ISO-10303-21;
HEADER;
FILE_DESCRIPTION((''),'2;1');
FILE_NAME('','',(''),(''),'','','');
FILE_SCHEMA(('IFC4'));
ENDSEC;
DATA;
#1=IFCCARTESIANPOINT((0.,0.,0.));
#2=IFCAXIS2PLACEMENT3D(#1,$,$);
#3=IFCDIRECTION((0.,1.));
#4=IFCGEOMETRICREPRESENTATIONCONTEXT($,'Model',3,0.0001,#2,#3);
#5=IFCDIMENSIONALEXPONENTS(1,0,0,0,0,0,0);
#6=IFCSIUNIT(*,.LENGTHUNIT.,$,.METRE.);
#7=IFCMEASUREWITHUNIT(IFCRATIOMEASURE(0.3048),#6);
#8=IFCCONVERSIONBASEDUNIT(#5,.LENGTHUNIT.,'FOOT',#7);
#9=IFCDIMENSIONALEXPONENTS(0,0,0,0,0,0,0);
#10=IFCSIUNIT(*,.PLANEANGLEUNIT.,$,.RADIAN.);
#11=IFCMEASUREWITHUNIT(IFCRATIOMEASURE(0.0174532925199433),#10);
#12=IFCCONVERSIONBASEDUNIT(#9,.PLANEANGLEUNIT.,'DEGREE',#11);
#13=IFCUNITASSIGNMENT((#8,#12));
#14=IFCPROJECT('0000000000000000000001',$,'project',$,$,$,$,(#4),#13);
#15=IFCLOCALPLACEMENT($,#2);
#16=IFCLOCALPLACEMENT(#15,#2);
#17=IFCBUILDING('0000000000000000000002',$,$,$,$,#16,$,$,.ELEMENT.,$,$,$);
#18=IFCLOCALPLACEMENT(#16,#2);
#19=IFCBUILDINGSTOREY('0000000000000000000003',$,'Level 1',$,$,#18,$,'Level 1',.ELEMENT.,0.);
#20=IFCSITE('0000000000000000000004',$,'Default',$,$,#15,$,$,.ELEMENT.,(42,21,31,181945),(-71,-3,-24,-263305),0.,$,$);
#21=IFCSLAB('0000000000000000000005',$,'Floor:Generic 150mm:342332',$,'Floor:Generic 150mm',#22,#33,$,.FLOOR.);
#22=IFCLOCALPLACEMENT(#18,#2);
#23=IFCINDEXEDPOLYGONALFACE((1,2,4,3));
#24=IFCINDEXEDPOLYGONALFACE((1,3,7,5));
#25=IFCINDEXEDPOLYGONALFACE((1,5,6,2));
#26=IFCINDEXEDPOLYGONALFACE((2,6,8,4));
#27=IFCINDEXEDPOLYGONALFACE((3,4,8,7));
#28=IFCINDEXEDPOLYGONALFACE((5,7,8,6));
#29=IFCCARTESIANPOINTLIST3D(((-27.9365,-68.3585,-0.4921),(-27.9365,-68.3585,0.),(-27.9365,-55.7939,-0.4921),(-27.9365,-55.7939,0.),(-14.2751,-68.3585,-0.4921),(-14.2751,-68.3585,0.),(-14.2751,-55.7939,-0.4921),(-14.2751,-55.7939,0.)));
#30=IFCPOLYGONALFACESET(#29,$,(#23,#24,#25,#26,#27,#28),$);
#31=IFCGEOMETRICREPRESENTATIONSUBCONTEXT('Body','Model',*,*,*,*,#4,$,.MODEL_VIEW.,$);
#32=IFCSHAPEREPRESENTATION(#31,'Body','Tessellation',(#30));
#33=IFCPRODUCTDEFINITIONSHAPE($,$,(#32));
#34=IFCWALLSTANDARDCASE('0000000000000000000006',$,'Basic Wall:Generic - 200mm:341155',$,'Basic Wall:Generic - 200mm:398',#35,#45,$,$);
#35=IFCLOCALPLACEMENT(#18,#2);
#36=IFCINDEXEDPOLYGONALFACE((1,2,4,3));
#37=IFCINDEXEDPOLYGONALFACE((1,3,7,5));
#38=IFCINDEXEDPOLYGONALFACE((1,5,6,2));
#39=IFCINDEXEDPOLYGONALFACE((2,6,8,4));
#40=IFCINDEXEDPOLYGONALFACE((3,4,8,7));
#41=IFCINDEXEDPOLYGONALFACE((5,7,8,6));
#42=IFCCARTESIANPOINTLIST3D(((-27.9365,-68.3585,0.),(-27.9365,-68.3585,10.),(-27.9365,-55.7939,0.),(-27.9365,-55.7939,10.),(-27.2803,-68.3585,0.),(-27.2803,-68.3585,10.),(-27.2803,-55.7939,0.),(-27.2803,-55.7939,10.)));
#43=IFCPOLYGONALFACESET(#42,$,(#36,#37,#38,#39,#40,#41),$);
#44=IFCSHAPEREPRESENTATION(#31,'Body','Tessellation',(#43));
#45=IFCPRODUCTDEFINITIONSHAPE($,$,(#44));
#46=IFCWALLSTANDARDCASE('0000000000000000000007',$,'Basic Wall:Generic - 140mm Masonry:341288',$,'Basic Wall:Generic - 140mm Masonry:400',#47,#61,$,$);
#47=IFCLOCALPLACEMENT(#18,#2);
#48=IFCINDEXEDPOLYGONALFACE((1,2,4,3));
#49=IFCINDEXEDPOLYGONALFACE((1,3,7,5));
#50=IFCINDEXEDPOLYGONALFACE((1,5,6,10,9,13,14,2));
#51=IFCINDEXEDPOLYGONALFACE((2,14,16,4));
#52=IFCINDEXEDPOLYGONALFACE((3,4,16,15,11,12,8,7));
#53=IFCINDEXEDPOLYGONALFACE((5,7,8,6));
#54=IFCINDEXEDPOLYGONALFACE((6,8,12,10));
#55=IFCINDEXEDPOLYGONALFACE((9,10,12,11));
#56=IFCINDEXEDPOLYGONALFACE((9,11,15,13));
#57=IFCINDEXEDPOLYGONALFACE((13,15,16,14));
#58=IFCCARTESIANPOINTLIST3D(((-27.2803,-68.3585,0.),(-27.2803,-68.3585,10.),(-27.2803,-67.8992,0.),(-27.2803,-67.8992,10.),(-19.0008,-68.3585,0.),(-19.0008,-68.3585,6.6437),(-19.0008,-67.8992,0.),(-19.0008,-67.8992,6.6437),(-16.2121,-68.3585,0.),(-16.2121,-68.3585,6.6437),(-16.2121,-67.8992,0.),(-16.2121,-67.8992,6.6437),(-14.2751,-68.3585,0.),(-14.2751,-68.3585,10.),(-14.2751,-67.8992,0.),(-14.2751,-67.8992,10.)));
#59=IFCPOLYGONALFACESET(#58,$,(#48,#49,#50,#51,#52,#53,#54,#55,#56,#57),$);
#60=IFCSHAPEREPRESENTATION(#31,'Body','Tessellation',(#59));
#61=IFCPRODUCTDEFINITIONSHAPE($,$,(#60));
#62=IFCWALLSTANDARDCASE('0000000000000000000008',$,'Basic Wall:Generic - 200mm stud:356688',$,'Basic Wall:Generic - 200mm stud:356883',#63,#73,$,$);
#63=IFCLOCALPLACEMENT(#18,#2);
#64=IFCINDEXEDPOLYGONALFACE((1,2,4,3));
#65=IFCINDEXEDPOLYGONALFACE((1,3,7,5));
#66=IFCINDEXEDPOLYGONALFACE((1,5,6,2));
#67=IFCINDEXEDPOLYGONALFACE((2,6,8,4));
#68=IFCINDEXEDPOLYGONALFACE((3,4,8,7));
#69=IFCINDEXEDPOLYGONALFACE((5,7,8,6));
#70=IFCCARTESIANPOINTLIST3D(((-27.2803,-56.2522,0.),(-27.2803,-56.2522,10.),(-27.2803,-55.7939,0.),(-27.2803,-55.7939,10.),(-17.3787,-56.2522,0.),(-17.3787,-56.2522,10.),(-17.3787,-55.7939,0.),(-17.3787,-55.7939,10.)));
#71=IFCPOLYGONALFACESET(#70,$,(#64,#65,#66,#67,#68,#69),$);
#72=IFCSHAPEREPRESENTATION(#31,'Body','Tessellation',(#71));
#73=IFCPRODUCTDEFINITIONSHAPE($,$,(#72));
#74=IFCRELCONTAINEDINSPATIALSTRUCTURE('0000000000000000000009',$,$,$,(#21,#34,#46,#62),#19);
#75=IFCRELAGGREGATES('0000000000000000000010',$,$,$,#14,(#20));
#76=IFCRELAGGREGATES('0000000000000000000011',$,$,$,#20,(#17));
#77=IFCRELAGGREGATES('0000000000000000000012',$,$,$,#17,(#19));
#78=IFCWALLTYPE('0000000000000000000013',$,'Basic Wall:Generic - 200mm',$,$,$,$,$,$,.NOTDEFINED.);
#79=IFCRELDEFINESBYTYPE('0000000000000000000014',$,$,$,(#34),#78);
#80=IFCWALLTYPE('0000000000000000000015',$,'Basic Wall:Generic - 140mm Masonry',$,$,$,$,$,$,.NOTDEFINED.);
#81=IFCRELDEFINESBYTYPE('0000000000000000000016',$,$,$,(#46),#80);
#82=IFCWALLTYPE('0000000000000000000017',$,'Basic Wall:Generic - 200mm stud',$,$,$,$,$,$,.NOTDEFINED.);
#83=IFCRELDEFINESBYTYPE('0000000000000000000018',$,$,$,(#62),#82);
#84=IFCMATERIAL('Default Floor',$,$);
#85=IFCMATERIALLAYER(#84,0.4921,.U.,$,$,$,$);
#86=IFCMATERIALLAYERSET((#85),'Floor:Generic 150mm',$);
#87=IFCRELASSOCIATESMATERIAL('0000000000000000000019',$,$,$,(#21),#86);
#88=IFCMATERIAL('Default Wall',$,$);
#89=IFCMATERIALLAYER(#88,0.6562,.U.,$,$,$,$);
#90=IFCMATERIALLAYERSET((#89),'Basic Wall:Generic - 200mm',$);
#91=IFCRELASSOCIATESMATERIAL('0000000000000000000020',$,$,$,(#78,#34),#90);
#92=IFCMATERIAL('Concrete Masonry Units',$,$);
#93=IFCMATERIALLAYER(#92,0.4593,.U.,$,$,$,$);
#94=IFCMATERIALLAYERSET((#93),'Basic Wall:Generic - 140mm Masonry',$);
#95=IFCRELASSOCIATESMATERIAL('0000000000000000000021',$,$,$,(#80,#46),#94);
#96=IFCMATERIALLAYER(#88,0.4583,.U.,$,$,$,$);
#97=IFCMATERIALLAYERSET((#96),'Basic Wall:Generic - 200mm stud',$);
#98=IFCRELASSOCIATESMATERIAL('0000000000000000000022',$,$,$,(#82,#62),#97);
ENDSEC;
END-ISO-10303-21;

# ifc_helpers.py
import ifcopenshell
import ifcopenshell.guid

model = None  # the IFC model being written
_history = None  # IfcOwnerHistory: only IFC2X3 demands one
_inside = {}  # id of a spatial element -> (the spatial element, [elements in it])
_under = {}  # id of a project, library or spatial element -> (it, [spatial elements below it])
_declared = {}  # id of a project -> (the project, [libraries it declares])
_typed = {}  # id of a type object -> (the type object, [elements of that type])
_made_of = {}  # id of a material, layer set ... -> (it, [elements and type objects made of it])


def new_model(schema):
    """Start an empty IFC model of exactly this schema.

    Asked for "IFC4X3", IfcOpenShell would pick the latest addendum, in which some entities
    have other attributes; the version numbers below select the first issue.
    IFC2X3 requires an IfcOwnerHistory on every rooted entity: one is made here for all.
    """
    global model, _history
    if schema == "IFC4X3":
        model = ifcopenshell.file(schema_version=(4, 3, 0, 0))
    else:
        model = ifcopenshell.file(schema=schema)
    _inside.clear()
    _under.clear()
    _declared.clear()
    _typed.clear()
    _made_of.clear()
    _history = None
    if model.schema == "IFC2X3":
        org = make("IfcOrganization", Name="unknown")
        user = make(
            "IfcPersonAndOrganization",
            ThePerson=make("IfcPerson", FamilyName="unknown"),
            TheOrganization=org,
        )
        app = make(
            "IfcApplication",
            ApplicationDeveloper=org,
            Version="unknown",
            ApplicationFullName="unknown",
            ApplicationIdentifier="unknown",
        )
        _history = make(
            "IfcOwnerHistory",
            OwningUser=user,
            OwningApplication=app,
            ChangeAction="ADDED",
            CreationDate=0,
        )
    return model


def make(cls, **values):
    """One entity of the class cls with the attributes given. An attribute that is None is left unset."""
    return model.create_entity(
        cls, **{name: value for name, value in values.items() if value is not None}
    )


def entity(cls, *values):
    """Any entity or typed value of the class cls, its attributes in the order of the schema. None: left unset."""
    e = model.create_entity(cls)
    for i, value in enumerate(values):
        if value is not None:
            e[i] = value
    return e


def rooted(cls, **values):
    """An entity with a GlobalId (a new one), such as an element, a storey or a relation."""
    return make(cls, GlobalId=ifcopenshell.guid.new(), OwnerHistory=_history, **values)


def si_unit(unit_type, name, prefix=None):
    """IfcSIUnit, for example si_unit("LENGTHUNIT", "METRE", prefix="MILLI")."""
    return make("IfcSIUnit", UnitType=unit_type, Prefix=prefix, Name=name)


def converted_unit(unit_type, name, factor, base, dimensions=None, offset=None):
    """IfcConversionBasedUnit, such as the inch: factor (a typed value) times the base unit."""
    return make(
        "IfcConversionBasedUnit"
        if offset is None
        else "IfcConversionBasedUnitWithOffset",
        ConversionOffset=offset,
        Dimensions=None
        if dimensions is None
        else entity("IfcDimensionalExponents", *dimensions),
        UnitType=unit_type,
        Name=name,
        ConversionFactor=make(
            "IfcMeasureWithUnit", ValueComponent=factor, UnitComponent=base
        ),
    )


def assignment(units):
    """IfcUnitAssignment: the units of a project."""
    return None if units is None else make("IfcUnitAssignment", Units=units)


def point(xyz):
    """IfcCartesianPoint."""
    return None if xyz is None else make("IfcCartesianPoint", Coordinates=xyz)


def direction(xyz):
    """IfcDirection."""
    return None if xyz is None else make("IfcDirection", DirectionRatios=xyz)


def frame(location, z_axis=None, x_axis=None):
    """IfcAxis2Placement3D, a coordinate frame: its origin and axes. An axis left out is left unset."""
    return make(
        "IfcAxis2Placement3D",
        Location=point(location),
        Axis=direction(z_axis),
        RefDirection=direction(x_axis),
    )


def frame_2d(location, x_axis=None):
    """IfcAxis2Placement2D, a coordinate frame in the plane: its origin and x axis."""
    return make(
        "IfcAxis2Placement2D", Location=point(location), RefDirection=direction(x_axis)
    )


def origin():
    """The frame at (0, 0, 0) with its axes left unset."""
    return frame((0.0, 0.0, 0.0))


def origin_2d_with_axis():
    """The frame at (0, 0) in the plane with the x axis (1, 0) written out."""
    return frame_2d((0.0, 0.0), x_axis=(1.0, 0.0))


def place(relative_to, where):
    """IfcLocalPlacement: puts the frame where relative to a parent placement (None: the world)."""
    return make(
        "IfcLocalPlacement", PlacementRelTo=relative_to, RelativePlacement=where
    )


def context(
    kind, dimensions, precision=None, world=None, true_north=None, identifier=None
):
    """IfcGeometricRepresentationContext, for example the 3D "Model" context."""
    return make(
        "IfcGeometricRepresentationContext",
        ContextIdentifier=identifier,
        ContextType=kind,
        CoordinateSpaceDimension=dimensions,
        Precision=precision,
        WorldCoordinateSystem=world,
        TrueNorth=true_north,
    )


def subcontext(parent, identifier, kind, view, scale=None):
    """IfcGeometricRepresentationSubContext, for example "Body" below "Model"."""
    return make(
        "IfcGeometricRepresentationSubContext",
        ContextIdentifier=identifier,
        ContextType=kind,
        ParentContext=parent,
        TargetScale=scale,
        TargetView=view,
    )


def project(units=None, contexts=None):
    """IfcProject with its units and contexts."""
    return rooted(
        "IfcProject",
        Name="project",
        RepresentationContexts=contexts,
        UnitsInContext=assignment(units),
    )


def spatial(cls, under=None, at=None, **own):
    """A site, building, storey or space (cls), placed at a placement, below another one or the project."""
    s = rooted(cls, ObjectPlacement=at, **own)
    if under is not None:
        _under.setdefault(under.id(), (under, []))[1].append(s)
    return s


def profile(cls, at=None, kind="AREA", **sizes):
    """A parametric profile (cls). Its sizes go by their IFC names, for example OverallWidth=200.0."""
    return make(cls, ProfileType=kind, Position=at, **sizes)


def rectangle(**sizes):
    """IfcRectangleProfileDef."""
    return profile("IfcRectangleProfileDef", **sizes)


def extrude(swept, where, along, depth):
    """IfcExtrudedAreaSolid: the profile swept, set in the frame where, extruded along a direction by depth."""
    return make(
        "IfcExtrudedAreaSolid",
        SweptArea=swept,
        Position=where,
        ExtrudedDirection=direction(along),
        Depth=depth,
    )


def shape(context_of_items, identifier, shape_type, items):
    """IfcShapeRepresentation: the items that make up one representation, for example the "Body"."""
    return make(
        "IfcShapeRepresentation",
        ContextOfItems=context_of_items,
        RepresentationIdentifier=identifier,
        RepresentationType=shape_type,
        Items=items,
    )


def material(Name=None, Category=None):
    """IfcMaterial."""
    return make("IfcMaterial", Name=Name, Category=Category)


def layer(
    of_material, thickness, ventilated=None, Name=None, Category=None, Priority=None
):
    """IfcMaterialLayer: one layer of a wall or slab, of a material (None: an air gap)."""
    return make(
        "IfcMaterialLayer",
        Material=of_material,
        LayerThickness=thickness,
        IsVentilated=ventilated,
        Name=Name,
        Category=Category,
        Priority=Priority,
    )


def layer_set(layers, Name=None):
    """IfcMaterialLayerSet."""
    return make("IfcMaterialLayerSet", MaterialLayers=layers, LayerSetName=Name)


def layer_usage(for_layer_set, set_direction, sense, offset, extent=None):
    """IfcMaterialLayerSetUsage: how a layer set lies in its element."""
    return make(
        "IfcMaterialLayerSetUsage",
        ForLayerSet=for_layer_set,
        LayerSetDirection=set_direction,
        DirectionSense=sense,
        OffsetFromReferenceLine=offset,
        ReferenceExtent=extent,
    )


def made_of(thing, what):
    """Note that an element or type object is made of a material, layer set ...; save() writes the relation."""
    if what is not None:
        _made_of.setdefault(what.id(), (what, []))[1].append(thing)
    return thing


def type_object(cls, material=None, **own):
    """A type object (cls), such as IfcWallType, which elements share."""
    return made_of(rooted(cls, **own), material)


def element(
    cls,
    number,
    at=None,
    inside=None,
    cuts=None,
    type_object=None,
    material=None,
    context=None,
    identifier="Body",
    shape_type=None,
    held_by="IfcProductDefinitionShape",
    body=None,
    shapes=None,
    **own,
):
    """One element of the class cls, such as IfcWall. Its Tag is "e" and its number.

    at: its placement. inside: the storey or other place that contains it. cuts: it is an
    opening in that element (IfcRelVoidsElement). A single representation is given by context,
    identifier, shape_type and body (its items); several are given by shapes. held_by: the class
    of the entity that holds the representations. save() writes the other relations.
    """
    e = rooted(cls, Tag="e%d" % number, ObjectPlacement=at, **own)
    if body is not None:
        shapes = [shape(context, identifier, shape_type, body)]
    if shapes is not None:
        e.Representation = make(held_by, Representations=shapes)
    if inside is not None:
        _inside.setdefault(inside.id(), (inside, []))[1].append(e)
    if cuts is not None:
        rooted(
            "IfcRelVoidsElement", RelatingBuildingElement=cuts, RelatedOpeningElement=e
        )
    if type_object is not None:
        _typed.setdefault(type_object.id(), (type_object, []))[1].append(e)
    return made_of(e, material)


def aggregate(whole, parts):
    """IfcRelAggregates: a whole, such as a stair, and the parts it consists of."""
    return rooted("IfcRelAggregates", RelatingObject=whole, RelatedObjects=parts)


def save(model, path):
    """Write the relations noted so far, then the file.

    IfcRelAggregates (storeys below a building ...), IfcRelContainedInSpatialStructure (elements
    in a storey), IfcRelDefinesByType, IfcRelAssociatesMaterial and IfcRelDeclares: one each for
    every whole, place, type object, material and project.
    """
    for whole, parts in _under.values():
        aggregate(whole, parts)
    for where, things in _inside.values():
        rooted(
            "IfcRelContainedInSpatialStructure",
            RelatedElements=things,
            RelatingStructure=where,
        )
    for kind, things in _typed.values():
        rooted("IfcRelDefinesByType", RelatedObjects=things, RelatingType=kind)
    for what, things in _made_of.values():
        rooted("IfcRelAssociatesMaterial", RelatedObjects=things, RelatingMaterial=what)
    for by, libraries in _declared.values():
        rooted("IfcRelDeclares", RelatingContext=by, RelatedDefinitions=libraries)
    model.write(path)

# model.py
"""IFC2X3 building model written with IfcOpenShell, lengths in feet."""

from ifc_helpers import new_model, entity, si_unit, converted_unit, direction, frame, frame_2d, origin, origin_2d_with_axis, place, context, subcontext, project, spatial, rectangle, extrude, material, layer, layer_set, layer_usage, type_object, element, save


model = new_model("IFC2X3")

# Units and contexts
model_context = context("Model", 3, precision=0.0001, world=origin(), true_north=direction((0.0, 1.0)))
body_context = subcontext(model_context, "Body", "Model", "MODEL_VIEW")
ifc_project = project(units=[converted_unit("LENGTHUNIT", "FOOT", entity("IfcRatioMeasure", 0.3048), si_unit("LENGTHUNIT", "METRE"), dimensions=[1, 0, 0, 0, 0, 0, 0]), converted_unit("PLANEANGLEUNIT", "DEGREE", entity("IfcRatioMeasure", 0.0174532925199433), si_unit("PLANEANGLEUNIT", "RADIAN"), dimensions=[0, 0, 0, 0, 0, 0, 0])], contexts=[model_context])

# Site, building, storey
site_placement = place(None, origin())
site = spatial("IfcSite", under=ifc_project, at=site_placement, Name="Default", CompositionType="ELEMENT", RefLatitude=(42, 21, 31, 181945), RefLongitude=(-71, -3, -24, -263305), RefElevation=0.0)
building_placement = place(site_placement, origin())
building = spatial("IfcBuilding", under=site, at=building_placement, CompositionType="ELEMENT")
storey_placement = place(building_placement, origin())
storey = spatial("IfcBuildingStorey", under=building, at=storey_placement, Name="Level 1", LongName="Level 1", CompositionType="ELEMENT", Elevation=0.0)

# Slab
ifc_material_1 = material(Name="Default Floor")
ifc_layer_1 = layer(ifc_material_1, 0.4921, ventilated="UNKNOWN")
ifc_layer_set_1 = layer_set([ifc_layer_1], Name="Floor:Generic 150mm")
ifc_layer_usage_1 = layer_usage(ifc_layer_set_1, "AXIS3", "POSITIVE", 0.0)
slab_placement = place(storey_placement, origin())
element("IfcSlab", 1, at=slab_placement, inside=storey, material=ifc_layer_usage_1, Name="Floor:Generic 150mm:342332", ObjectType="Floor:Generic 150mm", PredefinedType="FLOOR", context=body_context, shape_type="SweptSolid", body=[
    extrude(rectangle(XDim=12.5646, YDim=13.6614, at=origin_2d_with_axis()), frame((-21.1058, -62.0762, 0.0), z_axis=(0.0, 0.0, -1.0), x_axis=(0.0, 1.0, 0.0)), (0.0, 0.0, 1.0), 0.4921),
])

# Wall
ifc_material_2 = material(Name="Default Wall")
ifc_layer_2 = layer(ifc_material_2, 0.6562, ventilated="UNKNOWN")
ifc_layer_set_2 = layer_set([ifc_layer_2], Name="Basic Wall:Generic - 200mm")
ifc_layer_usage_2 = layer_usage(ifc_layer_set_2, "AXIS2", "NEGATIVE", 0.3281)
wall_type_1 = type_object("IfcWallType", Name="Basic Wall:Generic - 200mm", PredefinedType="NOTDEFINED", material=ifc_layer_set_2)
wall_1_placement = place(storey_placement, frame((-27.6084, -55.7939, 0.0), z_axis=(0.0, 0.0, 1.0), x_axis=(0.0, -1.0, 0.0)))
element("IfcWallStandardCase", 2, at=wall_1_placement, inside=storey, type_object=wall_type_1, material=ifc_layer_usage_2, Name="Basic Wall:Generic - 200mm:341155", ObjectType="Basic Wall:Generic - 200mm:398", context=body_context, shape_type="SweptSolid", body=[
    extrude(rectangle(XDim=12.5646, YDim=0.6562, at=frame_2d((6.2823, 0.0), x_axis=(-1.0, 0.0))), origin(), (0.0, 0.0, 1.0), 10.0),
])

# Wall, opening
ifc_material_3 = material(Name="Concrete Masonry Units")
ifc_layer_3 = layer(ifc_material_3, 0.4593, ventilated="UNKNOWN")
ifc_layer_set_3 = layer_set([ifc_layer_3], Name="Basic Wall:Generic - 140mm Masonry")
ifc_layer_usage_3 = layer_usage(ifc_layer_set_3, "AXIS2", "NEGATIVE", 0.2297)
wall_type_2 = type_object("IfcWallType", Name="Basic Wall:Generic - 140mm Masonry", PredefinedType="NOTDEFINED", material=ifc_layer_set_3)
wall_2_placement = place(storey_placement, frame((-27.2803, -68.1289, 0.0)))
wall_2 = element("IfcWallStandardCase", 3, at=wall_2_placement, inside=storey, type_object=wall_type_2, material=ifc_layer_usage_3, Name="Basic Wall:Generic - 140mm Masonry:341288", ObjectType="Basic Wall:Generic - 140mm Masonry:400", context=body_context, shape_type="SweptSolid", body=[
    extrude(rectangle(XDim=13.0052, YDim=0.4593, at=frame_2d((6.5026, 0.0), x_axis=(-1.0, 0.0))), origin(), (0.0, 0.0, 1.0), 10.0),
])
opening_placement = place(wall_2_placement, frame((8.2795, -0.2297, 0.0)))
element("IfcOpeningElement", 4, at=opening_placement, cuts=wall_2, ObjectType="Opening", context=body_context, shape_type="SweptSolid", body=[
    extrude(rectangle(XDim=6.6437, YDim=2.7887, at=frame_2d((3.3218, 1.3944), x_axis=(1.0, 0.0))), frame((0.0, 0.0, 0.0), z_axis=(0.0, 1.0, 0.0), x_axis=(0.0, 0.0, 1.0)), (0.0, 0.0, 1.0), 0.4593),
])

# Wall
ifc_layer_4 = layer(ifc_material_2, 0.4583, ventilated="UNKNOWN")
ifc_layer_set_4 = layer_set([ifc_layer_4], Name="Basic Wall:Generic - 200mm stud")
ifc_layer_usage_4 = layer_usage(ifc_layer_set_4, "AXIS2", "NEGATIVE", 0.2292)
wall_type_3 = type_object("IfcWallType", Name="Basic Wall:Generic - 200mm stud", PredefinedType="NOTDEFINED", material=ifc_layer_set_4)
wall_3_placement = place(storey_placement, frame((-27.2803, -56.0231, 0.0)))
element("IfcWallStandardCase", 5, at=wall_3_placement, inside=storey, type_object=wall_type_3, material=ifc_layer_usage_4, Name="Basic Wall:Generic - 200mm stud:356688", ObjectType="Basic Wall:Generic - 200mm stud:356883", context=body_context, shape_type="SweptSolid", body=[
    extrude(rectangle(XDim=9.9016, YDim=0.4583, at=frame_2d((4.9508, 0.0), x_axis=(-1.0, 0.0))), origin(), (0.0, 0.0, 1.0), 10.0),
])

save(model, "model.ifc")
